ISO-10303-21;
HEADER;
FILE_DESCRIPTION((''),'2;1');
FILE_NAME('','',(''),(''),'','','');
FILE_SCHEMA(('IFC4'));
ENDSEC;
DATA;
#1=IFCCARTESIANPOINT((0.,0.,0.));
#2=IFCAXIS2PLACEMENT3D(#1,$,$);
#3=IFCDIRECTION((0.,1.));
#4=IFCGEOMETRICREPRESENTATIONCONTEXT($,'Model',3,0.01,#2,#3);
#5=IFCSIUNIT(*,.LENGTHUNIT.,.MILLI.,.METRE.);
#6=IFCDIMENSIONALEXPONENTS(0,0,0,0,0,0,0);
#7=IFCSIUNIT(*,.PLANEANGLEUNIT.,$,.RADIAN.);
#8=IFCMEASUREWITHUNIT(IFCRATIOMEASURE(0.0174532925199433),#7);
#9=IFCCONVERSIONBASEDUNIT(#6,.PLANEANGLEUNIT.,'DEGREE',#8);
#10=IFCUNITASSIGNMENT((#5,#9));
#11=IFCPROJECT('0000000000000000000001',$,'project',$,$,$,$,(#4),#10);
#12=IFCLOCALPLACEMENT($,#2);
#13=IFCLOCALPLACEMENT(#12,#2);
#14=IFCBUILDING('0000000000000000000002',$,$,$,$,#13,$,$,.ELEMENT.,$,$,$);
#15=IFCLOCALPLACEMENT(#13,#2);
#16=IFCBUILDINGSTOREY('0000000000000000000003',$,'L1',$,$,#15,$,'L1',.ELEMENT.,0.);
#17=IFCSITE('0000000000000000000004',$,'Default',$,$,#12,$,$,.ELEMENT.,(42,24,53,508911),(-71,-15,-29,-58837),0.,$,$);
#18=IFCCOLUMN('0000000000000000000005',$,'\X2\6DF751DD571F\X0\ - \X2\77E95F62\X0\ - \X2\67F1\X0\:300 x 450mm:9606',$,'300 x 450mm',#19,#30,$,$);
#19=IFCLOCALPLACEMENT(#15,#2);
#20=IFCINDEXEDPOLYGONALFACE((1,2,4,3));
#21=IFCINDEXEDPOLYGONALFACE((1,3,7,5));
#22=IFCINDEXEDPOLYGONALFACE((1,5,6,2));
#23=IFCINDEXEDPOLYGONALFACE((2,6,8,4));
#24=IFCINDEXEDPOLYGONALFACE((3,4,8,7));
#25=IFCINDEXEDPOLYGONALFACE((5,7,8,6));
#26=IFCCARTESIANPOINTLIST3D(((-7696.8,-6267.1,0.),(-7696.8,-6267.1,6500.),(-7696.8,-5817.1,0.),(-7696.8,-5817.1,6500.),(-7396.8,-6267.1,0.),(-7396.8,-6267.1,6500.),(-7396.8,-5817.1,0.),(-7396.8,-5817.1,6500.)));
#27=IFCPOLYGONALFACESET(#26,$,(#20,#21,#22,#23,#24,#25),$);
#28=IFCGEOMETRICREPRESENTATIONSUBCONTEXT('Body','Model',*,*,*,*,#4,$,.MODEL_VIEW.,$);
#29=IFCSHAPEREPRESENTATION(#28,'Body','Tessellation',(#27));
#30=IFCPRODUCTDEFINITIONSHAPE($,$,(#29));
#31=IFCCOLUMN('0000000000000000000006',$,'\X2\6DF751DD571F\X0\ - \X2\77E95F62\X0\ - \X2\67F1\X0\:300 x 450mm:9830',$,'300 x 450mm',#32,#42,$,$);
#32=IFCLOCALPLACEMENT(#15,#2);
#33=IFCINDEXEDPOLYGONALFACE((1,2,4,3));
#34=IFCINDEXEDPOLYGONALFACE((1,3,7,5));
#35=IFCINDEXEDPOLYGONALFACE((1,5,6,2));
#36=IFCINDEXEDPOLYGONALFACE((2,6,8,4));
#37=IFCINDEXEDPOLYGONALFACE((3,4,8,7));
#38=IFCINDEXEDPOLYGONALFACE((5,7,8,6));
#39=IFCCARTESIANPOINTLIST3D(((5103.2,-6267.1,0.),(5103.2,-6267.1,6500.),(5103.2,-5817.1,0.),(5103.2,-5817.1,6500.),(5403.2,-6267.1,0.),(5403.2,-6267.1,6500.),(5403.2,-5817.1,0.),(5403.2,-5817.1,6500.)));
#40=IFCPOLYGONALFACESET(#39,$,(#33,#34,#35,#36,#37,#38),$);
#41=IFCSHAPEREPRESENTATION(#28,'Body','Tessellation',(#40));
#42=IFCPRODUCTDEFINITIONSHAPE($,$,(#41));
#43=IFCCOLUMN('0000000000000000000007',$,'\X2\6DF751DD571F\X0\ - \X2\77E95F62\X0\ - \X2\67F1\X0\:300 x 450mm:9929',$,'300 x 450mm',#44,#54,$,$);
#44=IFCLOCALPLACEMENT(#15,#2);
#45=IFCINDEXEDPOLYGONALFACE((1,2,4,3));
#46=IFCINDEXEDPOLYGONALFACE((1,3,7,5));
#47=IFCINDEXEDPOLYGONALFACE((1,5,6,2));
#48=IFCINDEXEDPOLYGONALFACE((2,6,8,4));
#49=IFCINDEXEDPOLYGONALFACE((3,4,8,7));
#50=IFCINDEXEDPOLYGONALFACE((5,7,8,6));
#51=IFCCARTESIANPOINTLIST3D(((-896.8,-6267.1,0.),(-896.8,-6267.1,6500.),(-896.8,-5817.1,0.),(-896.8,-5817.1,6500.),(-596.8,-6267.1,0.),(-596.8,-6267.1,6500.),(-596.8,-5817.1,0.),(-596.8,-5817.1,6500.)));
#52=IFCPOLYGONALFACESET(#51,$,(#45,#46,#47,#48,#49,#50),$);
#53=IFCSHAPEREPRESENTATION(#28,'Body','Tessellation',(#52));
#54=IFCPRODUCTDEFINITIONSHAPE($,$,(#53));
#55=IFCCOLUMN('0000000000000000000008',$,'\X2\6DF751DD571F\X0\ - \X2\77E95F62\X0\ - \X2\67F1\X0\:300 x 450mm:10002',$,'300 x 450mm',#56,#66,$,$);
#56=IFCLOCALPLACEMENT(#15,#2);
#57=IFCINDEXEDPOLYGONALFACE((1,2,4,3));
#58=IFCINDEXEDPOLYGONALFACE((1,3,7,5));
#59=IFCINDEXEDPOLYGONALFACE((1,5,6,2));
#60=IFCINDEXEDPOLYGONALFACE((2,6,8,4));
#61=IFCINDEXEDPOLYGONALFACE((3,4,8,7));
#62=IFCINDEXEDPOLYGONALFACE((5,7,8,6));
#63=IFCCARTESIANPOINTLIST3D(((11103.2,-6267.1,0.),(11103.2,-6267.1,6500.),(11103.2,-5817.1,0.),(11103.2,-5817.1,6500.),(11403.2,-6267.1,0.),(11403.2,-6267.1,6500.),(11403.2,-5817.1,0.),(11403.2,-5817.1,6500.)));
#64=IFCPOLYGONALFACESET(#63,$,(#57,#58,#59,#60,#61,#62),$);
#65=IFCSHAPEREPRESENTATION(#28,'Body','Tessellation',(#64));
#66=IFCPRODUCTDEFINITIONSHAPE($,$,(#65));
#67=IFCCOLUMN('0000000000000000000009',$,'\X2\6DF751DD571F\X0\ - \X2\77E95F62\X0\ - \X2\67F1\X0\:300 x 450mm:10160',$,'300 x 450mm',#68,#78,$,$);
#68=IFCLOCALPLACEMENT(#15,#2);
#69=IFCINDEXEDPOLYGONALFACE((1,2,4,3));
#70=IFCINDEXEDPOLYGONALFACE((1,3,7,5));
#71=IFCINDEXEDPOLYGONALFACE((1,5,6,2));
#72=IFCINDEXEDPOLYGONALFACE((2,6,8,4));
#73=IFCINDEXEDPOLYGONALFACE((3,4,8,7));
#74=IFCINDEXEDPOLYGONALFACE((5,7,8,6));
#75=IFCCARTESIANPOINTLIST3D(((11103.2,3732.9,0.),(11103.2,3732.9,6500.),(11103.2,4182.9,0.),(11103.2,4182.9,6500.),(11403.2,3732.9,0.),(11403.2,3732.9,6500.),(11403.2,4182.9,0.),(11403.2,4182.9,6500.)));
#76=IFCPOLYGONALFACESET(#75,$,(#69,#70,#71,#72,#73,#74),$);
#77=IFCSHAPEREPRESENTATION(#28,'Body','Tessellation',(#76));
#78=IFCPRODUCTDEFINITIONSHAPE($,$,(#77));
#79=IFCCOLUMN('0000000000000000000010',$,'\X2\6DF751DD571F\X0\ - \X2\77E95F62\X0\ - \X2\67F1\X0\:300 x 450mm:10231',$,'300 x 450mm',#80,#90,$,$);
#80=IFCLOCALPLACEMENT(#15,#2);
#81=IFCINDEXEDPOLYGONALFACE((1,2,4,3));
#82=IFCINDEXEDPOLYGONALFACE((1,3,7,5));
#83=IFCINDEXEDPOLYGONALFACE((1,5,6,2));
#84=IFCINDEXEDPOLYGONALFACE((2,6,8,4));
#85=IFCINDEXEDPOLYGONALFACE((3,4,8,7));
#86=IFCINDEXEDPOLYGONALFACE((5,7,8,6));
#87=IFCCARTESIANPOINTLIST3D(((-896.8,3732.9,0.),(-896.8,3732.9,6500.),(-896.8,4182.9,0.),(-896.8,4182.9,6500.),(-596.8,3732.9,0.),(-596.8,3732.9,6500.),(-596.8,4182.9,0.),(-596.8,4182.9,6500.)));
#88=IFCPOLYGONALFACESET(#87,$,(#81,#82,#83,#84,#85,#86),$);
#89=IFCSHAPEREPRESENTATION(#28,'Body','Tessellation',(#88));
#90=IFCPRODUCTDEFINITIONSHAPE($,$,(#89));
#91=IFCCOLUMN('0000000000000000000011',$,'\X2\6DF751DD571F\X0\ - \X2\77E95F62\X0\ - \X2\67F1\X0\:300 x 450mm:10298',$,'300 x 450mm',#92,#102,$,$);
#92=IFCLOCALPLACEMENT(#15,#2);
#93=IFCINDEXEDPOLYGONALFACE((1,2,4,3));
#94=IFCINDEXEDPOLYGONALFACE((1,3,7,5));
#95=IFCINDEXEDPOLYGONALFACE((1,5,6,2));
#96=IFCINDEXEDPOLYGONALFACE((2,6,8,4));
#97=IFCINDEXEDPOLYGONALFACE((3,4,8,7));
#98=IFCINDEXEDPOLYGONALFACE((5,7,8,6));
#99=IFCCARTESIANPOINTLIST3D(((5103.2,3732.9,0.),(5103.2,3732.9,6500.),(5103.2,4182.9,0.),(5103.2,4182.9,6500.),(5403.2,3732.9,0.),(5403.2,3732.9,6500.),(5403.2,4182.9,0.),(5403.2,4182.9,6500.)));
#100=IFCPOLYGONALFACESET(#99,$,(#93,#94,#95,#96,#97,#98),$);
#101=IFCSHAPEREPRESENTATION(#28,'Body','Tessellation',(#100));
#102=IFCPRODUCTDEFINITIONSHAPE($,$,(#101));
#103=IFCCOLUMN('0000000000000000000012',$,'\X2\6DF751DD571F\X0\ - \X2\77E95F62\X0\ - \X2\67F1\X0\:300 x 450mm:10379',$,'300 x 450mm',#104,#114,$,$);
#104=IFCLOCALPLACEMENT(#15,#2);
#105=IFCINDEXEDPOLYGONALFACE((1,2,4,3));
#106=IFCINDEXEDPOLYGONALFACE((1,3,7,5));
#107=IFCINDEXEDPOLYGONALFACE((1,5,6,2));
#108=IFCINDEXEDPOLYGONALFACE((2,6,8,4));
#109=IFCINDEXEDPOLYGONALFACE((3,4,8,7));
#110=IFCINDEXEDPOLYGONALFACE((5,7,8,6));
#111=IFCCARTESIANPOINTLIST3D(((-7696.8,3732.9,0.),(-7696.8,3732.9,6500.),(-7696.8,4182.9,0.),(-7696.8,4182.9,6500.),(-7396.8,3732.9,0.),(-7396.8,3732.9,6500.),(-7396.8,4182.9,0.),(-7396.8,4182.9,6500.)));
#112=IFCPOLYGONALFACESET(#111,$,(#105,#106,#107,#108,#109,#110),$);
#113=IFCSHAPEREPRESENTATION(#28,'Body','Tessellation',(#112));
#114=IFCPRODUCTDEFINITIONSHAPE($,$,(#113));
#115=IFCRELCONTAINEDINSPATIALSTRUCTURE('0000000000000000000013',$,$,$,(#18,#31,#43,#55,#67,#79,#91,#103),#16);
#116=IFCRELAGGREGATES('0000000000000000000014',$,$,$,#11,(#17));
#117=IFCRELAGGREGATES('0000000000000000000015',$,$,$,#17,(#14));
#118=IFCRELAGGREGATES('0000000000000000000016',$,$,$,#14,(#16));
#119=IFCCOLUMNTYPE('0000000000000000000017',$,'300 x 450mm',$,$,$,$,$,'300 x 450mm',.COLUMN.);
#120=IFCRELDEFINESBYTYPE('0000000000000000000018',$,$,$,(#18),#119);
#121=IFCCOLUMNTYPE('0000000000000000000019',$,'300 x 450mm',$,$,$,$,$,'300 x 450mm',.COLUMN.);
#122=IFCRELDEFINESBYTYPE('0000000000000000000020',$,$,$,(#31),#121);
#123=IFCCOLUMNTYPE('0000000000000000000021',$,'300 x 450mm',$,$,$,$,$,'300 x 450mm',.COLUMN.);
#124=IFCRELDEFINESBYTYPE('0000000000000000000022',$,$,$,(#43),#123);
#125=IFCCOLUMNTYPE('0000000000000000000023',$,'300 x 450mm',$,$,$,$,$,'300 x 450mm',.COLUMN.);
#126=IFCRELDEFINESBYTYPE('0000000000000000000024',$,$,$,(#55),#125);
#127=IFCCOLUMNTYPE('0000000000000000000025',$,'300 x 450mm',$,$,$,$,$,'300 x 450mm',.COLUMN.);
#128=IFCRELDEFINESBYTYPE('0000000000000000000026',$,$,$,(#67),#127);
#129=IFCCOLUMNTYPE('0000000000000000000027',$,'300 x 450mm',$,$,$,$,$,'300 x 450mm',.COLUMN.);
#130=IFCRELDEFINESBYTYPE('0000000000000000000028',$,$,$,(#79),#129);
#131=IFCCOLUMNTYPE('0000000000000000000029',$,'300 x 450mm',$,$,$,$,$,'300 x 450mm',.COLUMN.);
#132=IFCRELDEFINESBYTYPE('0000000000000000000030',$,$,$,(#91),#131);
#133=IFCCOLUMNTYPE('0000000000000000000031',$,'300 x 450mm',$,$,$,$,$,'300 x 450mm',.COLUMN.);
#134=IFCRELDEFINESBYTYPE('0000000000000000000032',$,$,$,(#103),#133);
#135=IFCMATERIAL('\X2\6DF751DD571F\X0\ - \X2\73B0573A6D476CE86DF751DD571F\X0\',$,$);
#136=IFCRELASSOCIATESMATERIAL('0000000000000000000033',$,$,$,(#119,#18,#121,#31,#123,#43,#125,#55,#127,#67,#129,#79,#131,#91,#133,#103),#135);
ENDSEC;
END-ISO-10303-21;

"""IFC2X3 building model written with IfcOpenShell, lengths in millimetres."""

from ifc_helpers import new_model, entity, si_unit, converted_unit, direction, frame, frame_2d, origin, origin_2d_with_axis, place, context, subcontext, project, spatial, rectangle, extrude, source, transform, mapped, material, type_object, type_shapes, element, save


model = new_model("IFC2X3")

# Units and contexts
model_context = context("Model", 3, precision=0.01, world=origin(), true_north=direction((0.0, 1.0)))
body_context = subcontext(model_context, "Body", "Model", "MODEL_VIEW")
ifc_project = project(units=[si_unit("LENGTHUNIT", "METRE", prefix="MILLI"), converted_unit("PLANEANGLEUNIT", "DEGREE", entity("IfcRatioMeasure", 0.0174532925199433), si_unit("PLANEANGLEUNIT", "RADIAN"), dimensions=[0, 0, 0, 0, 0, 0, 0])], contexts=[model_context])

# Site, building, storey
site_placement = place(None, origin())
site = spatial("IfcSite", under=ifc_project, at=site_placement, Name="Default", CompositionType="ELEMENT", RefLatitude=(42, 24, 53, 508911), RefLongitude=(-71, -15, -29, -58837), RefElevation=0.0)
building_placement = place(site_placement, origin())
building = spatial("IfcBuilding", under=site, at=building_placement, CompositionType="ELEMENT")
storey_placement = place(building_placement, origin())
storey = spatial("IfcBuildingStorey", under=building, at=storey_placement, Name="L1", LongName="L1", CompositionType="ELEMENT", Elevation=0.0)

# Columns
ifc_material = material(Name="混凝土 - 现场浇注混凝土")
column_type_1 = type_object("IfcColumnType", Name="300 x 450mm", ElementType="300 x 450mm", PredefinedType="COLUMN", material=ifc_material)
shared_shape_1 = source(origin(), body_context, "Body", "SweptSolid", [
    extrude(rectangle(XDim=450.0, YDim=300.0, at=frame_2d((0.0, 0.0), x_axis=(1.0, 0.0))), frame((-7546.8, -6042.1, 0.0), z_axis=(0.0, 0.0, 1.0), x_axis=(0.0, -1.0, 0.0)), (0.0, 0.0, 1.0), 6500.0),
])
type_shapes(column_type_1, [shared_shape_1])
column_1_placement = place(storey_placement, origin())
element("IfcColumn", 1, at=column_1_placement, inside=storey, type_object=column_type_1, material=ifc_material, Name="混凝土 - 矩形 - 柱:300 x 450mm:9606", ObjectType="300 x 450mm", context=body_context, shape_type="MappedRepresentation", body=[
    mapped(shared_shape_1, transform((0.0, 0.0, 0.0), scale=1.0)),
])
column_type_2 = type_object("IfcColumnType", Name="300 x 450mm", ElementType="300 x 450mm", PredefinedType="COLUMN", material=ifc_material)
shared_shape_2 = source(origin(), body_context, "Body", "SweptSolid", [
    extrude(rectangle(XDim=450.0, YDim=300.0, at=frame_2d((0.0, 0.0), x_axis=(1.0, 0.0))), frame((5253.2, -6042.1, 0.0), z_axis=(0.0, 0.0, 1.0), x_axis=(0.0, -1.0, 0.0)), (0.0, 0.0, 1.0), 6500.0),
])
type_shapes(column_type_2, [shared_shape_2])
column_2_placement = place(storey_placement, origin())
element("IfcColumn", 2, at=column_2_placement, inside=storey, type_object=column_type_2, material=ifc_material, Name="混凝土 - 矩形 - 柱:300 x 450mm:9830", ObjectType="300 x 450mm", context=body_context, shape_type="MappedRepresentation", body=[
    mapped(shared_shape_2, transform((0.0, 0.0, 0.0), scale=1.0)),
])
column_type_3 = type_object("IfcColumnType", Name="300 x 450mm", ElementType="300 x 450mm", PredefinedType="COLUMN", material=ifc_material)
shared_shape_3 = source(origin(), body_context, "Body", "SweptSolid", [
    extrude(rectangle(XDim=450.0, YDim=300.0, at=frame_2d((0.0, 0.0), x_axis=(1.0, 0.0))), frame((-746.8, -6042.1, 0.0), z_axis=(0.0, 0.0, 1.0), x_axis=(0.0, -1.0, 0.0)), (0.0, 0.0, 1.0), 6500.0),
])
type_shapes(column_type_3, [shared_shape_3])
column_3_placement = place(storey_placement, origin())
element("IfcColumn", 3, at=column_3_placement, inside=storey, type_object=column_type_3, material=ifc_material, Name="混凝土 - 矩形 - 柱:300 x 450mm:9929", ObjectType="300 x 450mm", context=body_context, shape_type="MappedRepresentation", body=[
    mapped(shared_shape_3, transform((0.0, 0.0, 0.0), scale=1.0)),
])
column_type_4 = type_object("IfcColumnType", Name="300 x 450mm", ElementType="300 x 450mm", PredefinedType="COLUMN", material=ifc_material)
shared_shape_4 = source(origin(), body_context, "Body", "SweptSolid", [
    extrude(rectangle(XDim=450.0, YDim=300.0, at=origin_2d_with_axis()), frame((11253.2, -6042.1, 0.0), z_axis=(0.0, 0.0, 1.0), x_axis=(0.0, -1.0, 0.0)), (0.0, 0.0, 1.0), 6500.0),
])
type_shapes(column_type_4, [shared_shape_4])
column_4_placement = place(storey_placement, origin())
element("IfcColumn", 4, at=column_4_placement, inside=storey, type_object=column_type_4, material=ifc_material, Name="混凝土 - 矩形 - 柱:300 x 450mm:10002", ObjectType="300 x 450mm", context=body_context, shape_type="MappedRepresentation", body=[
    mapped(shared_shape_4, transform((0.0, 0.0, 0.0), scale=1.0)),
])
column_type_5 = type_object("IfcColumnType", Name="300 x 450mm", ElementType="300 x 450mm", PredefinedType="COLUMN", material=ifc_material)
shared_shape_5 = source(origin(), body_context, "Body", "SweptSolid", [
    extrude(rectangle(XDim=450.0, YDim=300.0, at=frame_2d((0.0, 0.0), x_axis=(1.0, 0.0))), frame((11253.2, 3957.9, 0.0), z_axis=(0.0, 0.0, 1.0), x_axis=(0.0, -1.0, 0.0)), (0.0, 0.0, 1.0), 6500.0),
])
type_shapes(column_type_5, [shared_shape_5])
column_5_placement = place(storey_placement, origin())
element("IfcColumn", 5, at=column_5_placement, inside=storey, type_object=column_type_5, material=ifc_material, Name="混凝土 - 矩形 - 柱:300 x 450mm:10160", ObjectType="300 x 450mm", context=body_context, shape_type="MappedRepresentation", body=[
    mapped(shared_shape_5, transform((0.0, 0.0, 0.0), scale=1.0)),
])
column_type_6 = type_object("IfcColumnType", Name="300 x 450mm", ElementType="300 x 450mm", PredefinedType="COLUMN", material=ifc_material)
shared_shape_6 = source(origin(), body_context, "Body", "SweptSolid", [
    extrude(rectangle(XDim=450.0, YDim=300.0, at=frame_2d((0.0, 0.0), x_axis=(1.0, 0.0))), frame((-746.8, 3957.9, 0.0), z_axis=(0.0, 0.0, 1.0), x_axis=(0.0, -1.0, 0.0)), (0.0, 0.0, 1.0), 6500.0),
])
type_shapes(column_type_6, [shared_shape_6])
column_6_placement = place(storey_placement, origin())
element("IfcColumn", 6, at=column_6_placement, inside=storey, type_object=column_type_6, material=ifc_material, Name="混凝土 - 矩形 - 柱:300 x 450mm:10231", ObjectType="300 x 450mm", context=body_context, shape_type="MappedRepresentation", body=[
    mapped(shared_shape_6, transform((0.0, 0.0, 0.0), scale=1.0)),
])
column_type_7 = type_object("IfcColumnType", Name="300 x 450mm", ElementType="300 x 450mm", PredefinedType="COLUMN", material=ifc_material)
shared_shape_7 = source(origin(), body_context, "Body", "SweptSolid", [
    extrude(rectangle(XDim=450.0, YDim=300.0, at=frame_2d((0.0, 0.0), x_axis=(1.0, 0.0))), frame((5253.2, 3957.9, 0.0), z_axis=(0.0, 0.0, 1.0), x_axis=(0.0, -1.0, 0.0)), (0.0, 0.0, 1.0), 6500.0),
])
type_shapes(column_type_7, [shared_shape_7])
column_7_placement = place(storey_placement, origin())
element("IfcColumn", 7, at=column_7_placement, inside=storey, type_object=column_type_7, material=ifc_material, Name="混凝土 - 矩形 - 柱:300 x 450mm:10298", ObjectType="300 x 450mm", context=body_context, shape_type="MappedRepresentation", body=[
    mapped(shared_shape_7, transform((0.0, 0.0, 0.0), scale=1.0)),
])
column_type_8 = type_object("IfcColumnType", Name="300 x 450mm", ElementType="300 x 450mm", PredefinedType="COLUMN", material=ifc_material)
shared_shape_8 = source(origin(), body_context, "Body", "SweptSolid", [
    extrude(rectangle(XDim=450.0, YDim=300.0, at=frame_2d((0.0, 0.0), x_axis=(1.0, 0.0))), frame((-7546.8, 3957.9, 0.0), z_axis=(0.0, 0.0, 1.0), x_axis=(0.0, -1.0, 0.0)), (0.0, 0.0, 1.0), 6500.0),
])
type_shapes(column_type_8, [shared_shape_8])
column_8_placement = place(storey_placement, origin())
element("IfcColumn", 8, at=column_8_placement, inside=storey, type_object=column_type_8, material=ifc_material, Name="混凝土 - 矩形 - 柱:300 x 450mm:10379", ObjectType="300 x 450mm", context=body_context, shape_type="MappedRepresentation", body=[
    mapped(shared_shape_8, transform((0.0, 0.0, 0.0), scale=1.0)),
])

save(model, "model.ifc")
